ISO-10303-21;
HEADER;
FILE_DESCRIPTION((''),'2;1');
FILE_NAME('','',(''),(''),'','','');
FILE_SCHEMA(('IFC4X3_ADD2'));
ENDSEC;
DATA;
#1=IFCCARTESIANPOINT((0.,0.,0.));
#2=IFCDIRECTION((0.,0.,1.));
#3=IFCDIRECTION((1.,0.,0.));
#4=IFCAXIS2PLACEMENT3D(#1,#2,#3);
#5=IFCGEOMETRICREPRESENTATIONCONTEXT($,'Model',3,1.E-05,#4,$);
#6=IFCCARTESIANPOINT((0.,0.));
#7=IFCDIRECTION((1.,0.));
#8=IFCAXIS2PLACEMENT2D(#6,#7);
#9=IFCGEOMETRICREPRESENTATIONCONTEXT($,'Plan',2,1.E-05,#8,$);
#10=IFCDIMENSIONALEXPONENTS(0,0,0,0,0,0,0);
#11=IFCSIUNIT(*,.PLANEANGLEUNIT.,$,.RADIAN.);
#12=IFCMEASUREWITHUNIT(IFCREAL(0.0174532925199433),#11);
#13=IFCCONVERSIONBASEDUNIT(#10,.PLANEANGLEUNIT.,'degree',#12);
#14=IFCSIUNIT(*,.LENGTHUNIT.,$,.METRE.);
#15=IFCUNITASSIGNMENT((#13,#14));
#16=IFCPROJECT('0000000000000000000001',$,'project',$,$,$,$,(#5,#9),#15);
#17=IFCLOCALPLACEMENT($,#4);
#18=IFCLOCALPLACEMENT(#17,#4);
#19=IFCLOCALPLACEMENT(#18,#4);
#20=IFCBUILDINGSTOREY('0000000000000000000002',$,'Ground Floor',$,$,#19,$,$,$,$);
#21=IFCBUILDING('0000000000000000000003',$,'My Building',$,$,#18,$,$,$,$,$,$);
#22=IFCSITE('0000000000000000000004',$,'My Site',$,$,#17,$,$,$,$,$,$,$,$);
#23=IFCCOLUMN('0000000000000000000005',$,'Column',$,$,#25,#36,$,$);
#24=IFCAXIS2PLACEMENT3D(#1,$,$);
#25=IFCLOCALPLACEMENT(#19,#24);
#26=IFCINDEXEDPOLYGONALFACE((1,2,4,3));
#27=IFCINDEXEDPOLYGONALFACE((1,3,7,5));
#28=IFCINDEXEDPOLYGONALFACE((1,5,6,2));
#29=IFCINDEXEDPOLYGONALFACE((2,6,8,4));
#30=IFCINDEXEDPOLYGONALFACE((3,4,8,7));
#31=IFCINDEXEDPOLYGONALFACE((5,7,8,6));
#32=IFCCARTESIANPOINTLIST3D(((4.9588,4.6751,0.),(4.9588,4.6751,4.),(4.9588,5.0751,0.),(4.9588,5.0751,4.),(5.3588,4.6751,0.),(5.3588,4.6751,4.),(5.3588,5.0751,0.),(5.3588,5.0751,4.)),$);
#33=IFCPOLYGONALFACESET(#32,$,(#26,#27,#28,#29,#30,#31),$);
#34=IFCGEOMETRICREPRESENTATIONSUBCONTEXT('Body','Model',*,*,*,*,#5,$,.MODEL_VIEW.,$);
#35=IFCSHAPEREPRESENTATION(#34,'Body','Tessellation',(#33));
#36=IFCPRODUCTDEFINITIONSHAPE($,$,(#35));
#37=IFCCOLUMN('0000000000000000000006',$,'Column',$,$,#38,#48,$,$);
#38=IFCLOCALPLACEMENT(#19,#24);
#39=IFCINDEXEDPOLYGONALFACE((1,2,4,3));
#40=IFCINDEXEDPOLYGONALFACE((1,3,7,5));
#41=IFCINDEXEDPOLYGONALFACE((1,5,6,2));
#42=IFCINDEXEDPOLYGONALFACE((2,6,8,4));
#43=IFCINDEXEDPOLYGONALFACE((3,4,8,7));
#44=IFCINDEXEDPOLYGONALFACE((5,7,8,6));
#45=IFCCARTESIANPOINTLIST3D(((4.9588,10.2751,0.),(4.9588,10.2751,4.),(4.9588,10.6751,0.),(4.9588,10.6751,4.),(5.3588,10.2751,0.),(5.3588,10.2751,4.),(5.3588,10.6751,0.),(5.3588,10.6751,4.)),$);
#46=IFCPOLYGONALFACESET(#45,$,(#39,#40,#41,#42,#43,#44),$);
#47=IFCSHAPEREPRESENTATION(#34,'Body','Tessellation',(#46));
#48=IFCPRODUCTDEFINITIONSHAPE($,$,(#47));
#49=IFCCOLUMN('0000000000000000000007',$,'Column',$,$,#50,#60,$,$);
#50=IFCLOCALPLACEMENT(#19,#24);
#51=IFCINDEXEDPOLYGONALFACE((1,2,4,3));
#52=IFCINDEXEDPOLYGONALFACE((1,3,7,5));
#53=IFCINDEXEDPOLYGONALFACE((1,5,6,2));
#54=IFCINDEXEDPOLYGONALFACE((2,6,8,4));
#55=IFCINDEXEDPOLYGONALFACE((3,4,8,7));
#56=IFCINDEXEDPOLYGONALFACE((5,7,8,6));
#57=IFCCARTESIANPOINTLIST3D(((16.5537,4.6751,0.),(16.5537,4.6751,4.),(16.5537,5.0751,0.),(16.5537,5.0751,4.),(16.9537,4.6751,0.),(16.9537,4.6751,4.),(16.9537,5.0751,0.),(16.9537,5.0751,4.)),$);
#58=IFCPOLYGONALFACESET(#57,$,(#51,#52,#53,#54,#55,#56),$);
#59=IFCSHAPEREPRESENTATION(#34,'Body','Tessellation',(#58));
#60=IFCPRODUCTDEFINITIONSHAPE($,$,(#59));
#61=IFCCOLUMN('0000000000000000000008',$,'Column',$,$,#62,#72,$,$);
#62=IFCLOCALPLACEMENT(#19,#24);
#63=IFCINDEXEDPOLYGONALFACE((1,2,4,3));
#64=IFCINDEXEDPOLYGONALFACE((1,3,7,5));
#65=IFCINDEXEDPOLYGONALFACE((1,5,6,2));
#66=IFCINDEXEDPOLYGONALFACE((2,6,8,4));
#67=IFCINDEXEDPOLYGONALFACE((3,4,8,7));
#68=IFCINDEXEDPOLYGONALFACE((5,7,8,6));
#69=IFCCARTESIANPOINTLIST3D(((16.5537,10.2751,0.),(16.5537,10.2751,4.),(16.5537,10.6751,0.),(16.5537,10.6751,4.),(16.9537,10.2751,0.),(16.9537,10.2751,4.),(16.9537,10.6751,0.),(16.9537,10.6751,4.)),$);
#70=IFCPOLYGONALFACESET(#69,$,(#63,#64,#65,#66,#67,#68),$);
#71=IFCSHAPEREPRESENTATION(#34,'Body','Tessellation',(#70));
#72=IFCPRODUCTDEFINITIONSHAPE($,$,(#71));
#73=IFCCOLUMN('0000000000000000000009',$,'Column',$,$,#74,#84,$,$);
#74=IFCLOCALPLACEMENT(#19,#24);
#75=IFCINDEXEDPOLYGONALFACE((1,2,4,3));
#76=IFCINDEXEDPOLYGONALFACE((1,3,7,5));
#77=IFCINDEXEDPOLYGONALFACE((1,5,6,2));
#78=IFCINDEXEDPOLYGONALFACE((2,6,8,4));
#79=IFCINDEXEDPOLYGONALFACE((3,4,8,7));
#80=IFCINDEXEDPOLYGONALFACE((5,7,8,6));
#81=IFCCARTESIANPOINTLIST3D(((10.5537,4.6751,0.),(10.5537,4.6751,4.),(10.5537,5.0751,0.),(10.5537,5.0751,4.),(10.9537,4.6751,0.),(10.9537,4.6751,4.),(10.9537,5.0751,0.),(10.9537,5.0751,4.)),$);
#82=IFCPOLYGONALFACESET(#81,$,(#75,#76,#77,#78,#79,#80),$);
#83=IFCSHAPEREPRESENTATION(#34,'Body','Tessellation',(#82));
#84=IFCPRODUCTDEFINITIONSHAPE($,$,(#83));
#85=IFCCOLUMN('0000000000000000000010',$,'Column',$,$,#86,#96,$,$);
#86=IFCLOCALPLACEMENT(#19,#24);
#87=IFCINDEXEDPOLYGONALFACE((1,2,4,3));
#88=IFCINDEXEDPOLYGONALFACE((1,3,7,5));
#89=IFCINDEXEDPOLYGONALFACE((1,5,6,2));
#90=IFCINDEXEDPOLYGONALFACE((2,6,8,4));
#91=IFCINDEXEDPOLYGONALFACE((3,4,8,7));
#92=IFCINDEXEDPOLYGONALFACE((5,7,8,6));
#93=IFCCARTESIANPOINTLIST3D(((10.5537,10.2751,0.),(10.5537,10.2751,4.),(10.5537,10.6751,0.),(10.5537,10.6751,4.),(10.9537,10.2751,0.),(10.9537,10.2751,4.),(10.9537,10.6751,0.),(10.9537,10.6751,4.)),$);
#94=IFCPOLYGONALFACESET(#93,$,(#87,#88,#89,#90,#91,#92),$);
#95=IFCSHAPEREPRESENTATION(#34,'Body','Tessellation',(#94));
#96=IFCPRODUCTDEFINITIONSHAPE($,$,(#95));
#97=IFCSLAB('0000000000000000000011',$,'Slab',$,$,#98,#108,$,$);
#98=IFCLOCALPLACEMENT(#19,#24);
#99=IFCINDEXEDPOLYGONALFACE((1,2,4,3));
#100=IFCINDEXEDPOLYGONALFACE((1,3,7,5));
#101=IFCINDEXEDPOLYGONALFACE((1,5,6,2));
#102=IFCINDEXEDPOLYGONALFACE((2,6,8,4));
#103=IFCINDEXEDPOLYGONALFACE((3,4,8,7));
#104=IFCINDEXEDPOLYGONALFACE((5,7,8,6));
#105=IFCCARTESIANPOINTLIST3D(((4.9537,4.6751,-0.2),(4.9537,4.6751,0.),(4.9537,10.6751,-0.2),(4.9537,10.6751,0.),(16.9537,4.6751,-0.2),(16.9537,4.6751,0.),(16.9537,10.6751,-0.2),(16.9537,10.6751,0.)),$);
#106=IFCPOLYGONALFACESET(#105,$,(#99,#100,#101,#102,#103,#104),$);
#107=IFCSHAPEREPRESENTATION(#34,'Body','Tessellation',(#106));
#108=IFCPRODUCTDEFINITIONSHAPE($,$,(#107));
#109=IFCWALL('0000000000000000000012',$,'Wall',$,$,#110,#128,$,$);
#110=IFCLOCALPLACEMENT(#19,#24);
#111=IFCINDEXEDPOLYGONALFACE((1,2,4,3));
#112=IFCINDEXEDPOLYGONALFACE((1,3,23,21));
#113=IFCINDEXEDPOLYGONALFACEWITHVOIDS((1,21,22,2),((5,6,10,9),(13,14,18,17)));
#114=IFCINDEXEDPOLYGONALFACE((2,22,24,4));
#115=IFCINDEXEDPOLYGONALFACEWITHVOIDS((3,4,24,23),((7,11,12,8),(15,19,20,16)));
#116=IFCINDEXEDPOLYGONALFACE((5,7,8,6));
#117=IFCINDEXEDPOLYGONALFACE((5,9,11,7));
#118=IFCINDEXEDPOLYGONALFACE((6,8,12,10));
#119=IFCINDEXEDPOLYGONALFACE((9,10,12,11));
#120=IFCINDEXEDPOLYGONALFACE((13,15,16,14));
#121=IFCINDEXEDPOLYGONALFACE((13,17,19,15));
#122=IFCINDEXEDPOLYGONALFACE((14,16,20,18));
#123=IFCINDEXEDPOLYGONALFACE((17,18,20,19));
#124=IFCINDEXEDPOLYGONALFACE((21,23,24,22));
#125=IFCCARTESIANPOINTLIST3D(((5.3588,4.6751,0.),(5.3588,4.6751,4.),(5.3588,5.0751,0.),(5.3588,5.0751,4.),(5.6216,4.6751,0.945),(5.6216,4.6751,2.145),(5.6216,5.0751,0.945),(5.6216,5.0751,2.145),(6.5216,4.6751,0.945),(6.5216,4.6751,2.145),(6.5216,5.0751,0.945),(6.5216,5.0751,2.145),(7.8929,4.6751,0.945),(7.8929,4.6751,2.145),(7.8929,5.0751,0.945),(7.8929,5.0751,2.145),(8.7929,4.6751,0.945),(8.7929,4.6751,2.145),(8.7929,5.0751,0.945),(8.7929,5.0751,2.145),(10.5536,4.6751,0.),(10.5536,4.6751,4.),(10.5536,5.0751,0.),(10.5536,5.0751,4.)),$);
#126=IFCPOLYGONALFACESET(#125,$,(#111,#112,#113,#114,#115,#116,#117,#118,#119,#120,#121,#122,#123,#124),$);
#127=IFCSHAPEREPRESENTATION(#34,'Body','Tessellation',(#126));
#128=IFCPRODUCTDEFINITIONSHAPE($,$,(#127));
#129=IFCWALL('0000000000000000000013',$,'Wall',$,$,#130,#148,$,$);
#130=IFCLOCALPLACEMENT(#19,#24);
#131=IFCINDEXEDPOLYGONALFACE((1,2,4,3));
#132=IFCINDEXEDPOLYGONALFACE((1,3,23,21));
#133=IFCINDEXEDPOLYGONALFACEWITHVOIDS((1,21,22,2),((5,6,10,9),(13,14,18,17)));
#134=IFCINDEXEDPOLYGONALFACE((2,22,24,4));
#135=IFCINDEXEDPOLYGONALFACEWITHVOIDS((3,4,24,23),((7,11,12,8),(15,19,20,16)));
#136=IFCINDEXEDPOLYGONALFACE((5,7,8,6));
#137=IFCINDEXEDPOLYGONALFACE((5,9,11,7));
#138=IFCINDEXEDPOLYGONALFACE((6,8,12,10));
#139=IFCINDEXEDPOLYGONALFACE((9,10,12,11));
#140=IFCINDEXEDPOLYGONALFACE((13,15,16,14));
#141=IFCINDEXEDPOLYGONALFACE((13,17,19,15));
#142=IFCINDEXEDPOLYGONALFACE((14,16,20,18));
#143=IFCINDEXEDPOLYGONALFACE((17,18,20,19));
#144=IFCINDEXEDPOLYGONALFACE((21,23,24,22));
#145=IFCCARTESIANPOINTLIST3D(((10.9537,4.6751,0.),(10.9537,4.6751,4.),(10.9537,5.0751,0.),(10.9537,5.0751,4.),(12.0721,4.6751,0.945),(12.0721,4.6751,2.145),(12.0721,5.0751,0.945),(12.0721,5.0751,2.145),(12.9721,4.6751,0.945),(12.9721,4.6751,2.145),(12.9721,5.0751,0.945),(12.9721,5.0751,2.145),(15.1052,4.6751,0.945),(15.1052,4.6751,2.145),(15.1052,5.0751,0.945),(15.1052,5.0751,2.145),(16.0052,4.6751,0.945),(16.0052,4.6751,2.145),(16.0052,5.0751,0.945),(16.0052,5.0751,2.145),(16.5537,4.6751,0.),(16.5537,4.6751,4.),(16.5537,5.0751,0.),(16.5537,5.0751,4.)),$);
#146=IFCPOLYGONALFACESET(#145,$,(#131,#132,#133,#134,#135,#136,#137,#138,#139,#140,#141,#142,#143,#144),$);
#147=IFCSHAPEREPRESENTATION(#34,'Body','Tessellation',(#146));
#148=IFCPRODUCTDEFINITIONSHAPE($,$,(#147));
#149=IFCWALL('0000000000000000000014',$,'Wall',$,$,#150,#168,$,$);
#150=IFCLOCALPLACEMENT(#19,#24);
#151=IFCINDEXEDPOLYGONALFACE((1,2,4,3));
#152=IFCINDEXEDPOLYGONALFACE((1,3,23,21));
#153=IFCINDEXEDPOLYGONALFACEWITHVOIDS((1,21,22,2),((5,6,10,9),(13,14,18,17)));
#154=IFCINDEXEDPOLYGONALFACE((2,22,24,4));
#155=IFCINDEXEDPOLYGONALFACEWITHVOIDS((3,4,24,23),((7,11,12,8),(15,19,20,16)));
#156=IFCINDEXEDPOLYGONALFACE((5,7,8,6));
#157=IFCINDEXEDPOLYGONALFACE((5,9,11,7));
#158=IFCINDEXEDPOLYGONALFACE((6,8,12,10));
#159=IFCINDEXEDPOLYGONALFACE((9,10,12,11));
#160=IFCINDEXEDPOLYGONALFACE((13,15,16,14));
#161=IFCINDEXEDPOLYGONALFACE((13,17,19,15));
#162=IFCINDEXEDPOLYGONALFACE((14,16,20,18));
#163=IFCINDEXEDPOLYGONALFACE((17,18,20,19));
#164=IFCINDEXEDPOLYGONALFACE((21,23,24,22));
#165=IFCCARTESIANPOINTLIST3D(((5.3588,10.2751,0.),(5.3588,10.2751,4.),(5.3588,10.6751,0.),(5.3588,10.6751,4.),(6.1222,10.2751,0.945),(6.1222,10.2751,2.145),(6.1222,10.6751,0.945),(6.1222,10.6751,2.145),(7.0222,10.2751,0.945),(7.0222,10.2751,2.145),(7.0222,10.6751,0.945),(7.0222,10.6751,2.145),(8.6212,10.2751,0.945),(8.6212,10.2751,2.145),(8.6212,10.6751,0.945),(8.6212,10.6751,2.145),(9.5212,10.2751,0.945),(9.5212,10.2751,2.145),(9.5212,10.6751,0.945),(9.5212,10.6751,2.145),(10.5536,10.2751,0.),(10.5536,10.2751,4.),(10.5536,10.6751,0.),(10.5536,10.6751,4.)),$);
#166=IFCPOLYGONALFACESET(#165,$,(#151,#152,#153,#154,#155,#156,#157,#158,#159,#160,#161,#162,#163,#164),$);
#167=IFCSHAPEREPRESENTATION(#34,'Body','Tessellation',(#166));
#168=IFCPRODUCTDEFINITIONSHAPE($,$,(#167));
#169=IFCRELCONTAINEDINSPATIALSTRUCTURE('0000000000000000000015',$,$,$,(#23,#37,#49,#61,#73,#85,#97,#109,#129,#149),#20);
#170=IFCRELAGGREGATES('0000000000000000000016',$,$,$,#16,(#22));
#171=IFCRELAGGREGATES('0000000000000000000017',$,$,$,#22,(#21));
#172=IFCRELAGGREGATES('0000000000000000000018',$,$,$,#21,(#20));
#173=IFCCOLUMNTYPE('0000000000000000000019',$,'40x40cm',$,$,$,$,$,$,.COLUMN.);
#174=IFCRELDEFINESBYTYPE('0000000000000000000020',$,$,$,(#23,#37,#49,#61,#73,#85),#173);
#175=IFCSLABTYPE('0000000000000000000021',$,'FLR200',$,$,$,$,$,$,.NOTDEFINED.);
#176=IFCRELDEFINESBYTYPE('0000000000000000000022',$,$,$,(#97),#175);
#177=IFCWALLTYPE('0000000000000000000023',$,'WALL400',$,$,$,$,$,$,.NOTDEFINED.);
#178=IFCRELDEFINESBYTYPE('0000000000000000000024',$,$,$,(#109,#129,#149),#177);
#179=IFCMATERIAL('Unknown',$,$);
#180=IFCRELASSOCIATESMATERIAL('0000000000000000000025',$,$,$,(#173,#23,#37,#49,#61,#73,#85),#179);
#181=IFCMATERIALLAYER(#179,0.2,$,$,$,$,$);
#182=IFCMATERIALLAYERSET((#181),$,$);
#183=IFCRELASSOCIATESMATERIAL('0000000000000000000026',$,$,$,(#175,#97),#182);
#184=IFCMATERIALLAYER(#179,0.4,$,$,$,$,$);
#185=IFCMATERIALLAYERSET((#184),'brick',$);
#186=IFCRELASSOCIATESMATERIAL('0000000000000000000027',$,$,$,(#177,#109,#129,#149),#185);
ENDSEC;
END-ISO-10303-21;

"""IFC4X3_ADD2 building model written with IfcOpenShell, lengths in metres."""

from ifc_helpers import new_model, entity, si_unit, converted_unit, frame, origin_with_axes, origin_2d_with_axis, place, context, subcontext, project, spatial, line, indexed_curve, rectangle, outline, extrude, source, transform, mapped, material, layer, layer_set, layer_usage, material_profile, profile_set, profile_usage, type_object, element, save


model = new_model("IFC4X3_ADD2")

# Units and contexts
model_context = context("Model", 3, precision=1e-05, world=origin_with_axes())
plan_context = context("Plan", 2, precision=1e-05, world=origin_2d_with_axis())
body_context = subcontext(model_context, "Body", "Model", "MODEL_VIEW")
ifc_project = project(units=[converted_unit("PLANEANGLEUNIT", "degree", entity("IfcReal", 0.0174532925199433), si_unit("PLANEANGLEUNIT", "RADIAN"), dimensions=[0, 0, 0, 0, 0, 0, 0]), si_unit("LENGTHUNIT", "METRE")], contexts=[model_context, plan_context])

# Site, building, storey
site_placement = place(None, origin_with_axes())
site = spatial("IfcSite", under=ifc_project, at=site_placement, Name="My Site")
building_placement = place(site_placement, origin_with_axes())
building = spatial("IfcBuilding", under=site, at=building_placement, Name="My Building")
storey_placement = place(building_placement, origin_with_axes())
storey = spatial("IfcBuildingStorey", under=building, at=storey_placement, Name="Ground Floor")

# Columns
ifc_material = material(Name="Unknown")
ifc_material_profile = material_profile(ifc_material, rectangle(XDim=0.4, YDim=0.4))
ifc_profile_set = profile_set([ifc_material_profile])
ifc_profile_usage_1 = profile_usage(ifc_profile_set, cardinal=5)
column_type = type_object("IfcColumnType", Name="40x40cm", PredefinedType="COLUMN", material=ifc_profile_set)
column_1_placement = place(storey_placement, frame((5.1588, 4.8751, 0.0), z_axis=(0.0, 0.0, 1.0), x_axis=(1.0, 0.0, 0.0)))
element("IfcColumn", 1, at=column_1_placement, inside=storey, type_object=column_type, material=ifc_profile_usage_1, Name="Column", context=body_context, shape_type="SweptSolid", body=[
    extrude(rectangle(XDim=0.4, YDim=0.4), origin_with_axes(), (0.0, 0.0, 1.0), 4.0),
])
ifc_profile_usage_2 = profile_usage(ifc_profile_set, cardinal=5)
column_2_placement = place(storey_placement, frame((5.1588, 10.4751, 0.0), z_axis=(0.0, 0.0, 1.0), x_axis=(1.0, 0.0, 0.0)))
element("IfcColumn", 2, at=column_2_placement, inside=storey, type_object=column_type, material=ifc_profile_usage_2, Name="Column", context=body_context, shape_type="SweptSolid", body=[
    extrude(rectangle(XDim=0.4, YDim=0.4), origin_with_axes(), (0.0, 0.0, 1.0), 4.0),
])
ifc_profile_usage_3 = profile_usage(ifc_profile_set, cardinal=5)
column_3_placement = place(storey_placement, frame((16.7537, 4.8751, 0.0), z_axis=(0.0, 0.0, 1.0), x_axis=(1.0, 0.0, 0.0)))
element("IfcColumn", 3, at=column_3_placement, inside=storey, type_object=column_type, material=ifc_profile_usage_3, Name="Column", context=body_context, shape_type="SweptSolid", body=[
    extrude(rectangle(XDim=0.4, YDim=0.4), origin_with_axes(), (0.0, 0.0, 1.0), 4.0),
])
ifc_profile_usage_4 = profile_usage(ifc_profile_set, cardinal=5)
column_4_placement = place(storey_placement, frame((16.7537, 10.4751, 0.0), z_axis=(0.0, 0.0, 1.0), x_axis=(1.0, 0.0, 0.0)))
element("IfcColumn", 4, at=column_4_placement, inside=storey, type_object=column_type, material=ifc_profile_usage_4, Name="Column", context=body_context, shape_type="SweptSolid", body=[
    extrude(rectangle(XDim=0.4, YDim=0.4), origin_with_axes(), (0.0, 0.0, 1.0), 4.0),
])
ifc_profile_usage_5 = profile_usage(ifc_profile_set, cardinal=5)
column_5_placement = place(storey_placement, frame((10.7537, 4.8751, 0.0), z_axis=(0.0, 0.0, 1.0), x_axis=(1.0, 0.0, 0.0)))
element("IfcColumn", 5, at=column_5_placement, inside=storey, type_object=column_type, material=ifc_profile_usage_5, Name="Column", context=body_context, shape_type="SweptSolid", body=[
    extrude(rectangle(XDim=0.4, YDim=0.4), origin_with_axes(), (0.0, 0.0, 1.0), 4.0),
])
ifc_profile_usage_6 = profile_usage(ifc_profile_set, cardinal=5)
column_6_placement = place(storey_placement, frame((10.7537, 10.4751, 0.0), z_axis=(0.0, 0.0, 1.0), x_axis=(1.0, 0.0, 0.0)))
element("IfcColumn", 6, at=column_6_placement, inside=storey, type_object=column_type, material=ifc_profile_usage_6, Name="Column", context=body_context, shape_type="SweptSolid", body=[
    extrude(rectangle(XDim=0.4, YDim=0.4), origin_with_axes(), (0.0, 0.0, 1.0), 4.0),
])

# Slab
ifc_layer_1 = layer(ifc_material, 0.2)
ifc_layer_set_1 = layer_set([ifc_layer_1])
ifc_layer_usage_1 = layer_usage(ifc_layer_set_1, "AXIS3", "POSITIVE", -0.2)
slab_type = type_object("IfcSlabType", Name="FLR200", PredefinedType="NOTDEFINED", material=ifc_layer_set_1)
slab_placement = place(storey_placement, frame((4.9537, 4.6751, 0.0), z_axis=(0.0, 0.0, 1.0), x_axis=(1.0, 0.0, 0.0)))
element("IfcSlab", 7, at=slab_placement, inside=storey, type_object=slab_type, material=ifc_layer_usage_1, Name="Slab", context=body_context, shape_type="SweptSolid", body=[
    extrude(outline(indexed_curve([(0.0, 6.0), (12.0, 6.0), (12.0, 0.0), (0.0, 0.0), (0.0, 6.0)])), frame((0.0, 0.0, -0.2), z_axis=(0.0, 0.0, 1.0), x_axis=(1.0, 0.0, 0.0)), (0.0, 0.0, 1.0), 0.2),
])

# Walls, openings
ifc_layer_2 = layer(ifc_material, 0.4)
ifc_layer_set_2 = layer_set([ifc_layer_2], Name="brick")
ifc_layer_usage_2 = layer_usage(ifc_layer_set_2, "AXIS2", "POSITIVE", 0.0)
wall_type = type_object("IfcWallType", Name="WALL400", PredefinedType="NOTDEFINED", material=ifc_layer_set_2)
wall_1_placement = place(storey_placement, frame((5.3588, 4.6751, 0.0), z_axis=(0.0, 0.0, 1.0), x_axis=(1.0, 0.0, 0.0)))
wall_1 = element("IfcWall", 8, at=wall_1_placement, inside=storey, type_object=wall_type, material=ifc_layer_usage_2, Name="Wall", context=body_context, shape_type="SweptSolid", body=[
    extrude(outline(indexed_curve([(0.0, 0.0), (0.0, 0.4), (5.1949, 0.4), (5.1949, 0.0)], segments=[line(1, 2, 3, 4, 1)])), origin_with_axes(), (0.0, 0.0, 1.0), 4.0),
])
shared_shape_1 = source(origin_with_axes(), body_context, "Body", "SweptSolid", [
    extrude(outline(indexed_curve([(0.0, 0.0), (0.9, 0.0), (0.9, 1.2), (0.0, 1.2)], segments=[line(1, 2, 3, 4, 1)])), frame((0.0, -0.6, 0.0), z_axis=(0.0, -1.0, 0.0), x_axis=(1.0, 0.0, 0.0)), (0.0, 0.0, -1.0), 1.2),
])
opening_1_placement = place(wall_1_placement, frame((0.2628, 0.0, 0.945), z_axis=(0.0, 0.0, 1.0), x_axis=(1.0, 0.0, 0.0)))
element("IfcOpeningElement", 9, at=opening_1_placement, cuts=wall_1, PredefinedType="OPENING", context=body_context, shape_type="MappedRepresentation", body=[
    mapped(shared_shape_1, transform((0.0, 0.0, 0.0), x_axis=(1.0, 0.0, 0.0), y_axis=(0.0, 1.0, 0.0), z_axis=(0.0, 0.0, 1.0), scale=1.0)),
])
opening_2_placement = place(wall_1_placement, frame((2.5341, 0.0, 0.945), z_axis=(0.0, 0.0, 1.0), x_axis=(1.0, 0.0, 0.0)))
element("IfcOpeningElement", 10, at=opening_2_placement, cuts=wall_1, PredefinedType="OPENING", context=body_context, shape_type="MappedRepresentation", body=[
    mapped(shared_shape_1, transform((0.0, 0.0, 0.0), x_axis=(1.0, 0.0, 0.0), y_axis=(0.0, 1.0, 0.0), z_axis=(0.0, 0.0, 1.0), scale=1.0)),
])
ifc_layer_usage_3 = layer_usage(ifc_layer_set_2, "AXIS2", "POSITIVE", 0.0)
wall_2_placement = place(storey_placement, frame((10.9537, 4.6751, 0.0), z_axis=(0.0, 0.0, 1.0), x_axis=(1.0, 0.0, 0.0)))
wall_2 = element("IfcWall", 11, at=wall_2_placement, inside=storey, type_object=wall_type, material=ifc_layer_usage_3, Name="Wall", context=body_context, shape_type="SweptSolid", body=[
    extrude(outline(indexed_curve([(0.0, 0.0), (0.0, 0.4), (5.6, 0.4), (5.6, 0.0)], segments=[line(1, 2, 3, 4, 1)])), origin_with_axes(), (0.0, 0.0, 1.0), 4.0),
])
opening_3_placement = place(wall_2_placement, frame((1.1184, 0.0, 0.945), z_axis=(0.0, 0.0, 1.0), x_axis=(1.0, 0.0, 0.0)))
element("IfcOpeningElement", 12, at=opening_3_placement, cuts=wall_2, PredefinedType="OPENING", context=body_context, shape_type="MappedRepresentation", body=[
    mapped(shared_shape_1, transform((0.0, 0.0, 0.0), x_axis=(1.0, 0.0, 0.0), y_axis=(0.0, 1.0, 0.0), z_axis=(0.0, 0.0, 1.0), scale=1.0)),
])
opening_4_placement = place(wall_2_placement, frame((4.1515, 0.0, 0.945), z_axis=(0.0, 0.0, 1.0), x_axis=(1.0, 0.0, 0.0)))
element("IfcOpeningElement", 13, at=opening_4_placement, cuts=wall_2, PredefinedType="OPENING", context=body_context, shape_type="MappedRepresentation", body=[
    mapped(shared_shape_1, transform((0.0, 0.0, 0.0), x_axis=(1.0, 0.0, 0.0), y_axis=(0.0, 1.0, 0.0), z_axis=(0.0, 0.0, 1.0), scale=1.0)),
])
ifc_layer_usage_4 = layer_usage(ifc_layer_set_2, "AXIS2", "POSITIVE", 0.0)
wall_3_placement = place(storey_placement, frame((5.3588, 10.2751, 0.0), z_axis=(0.0, 0.0, 1.0), x_axis=(1.0, 0.0, 0.0)))
wall_3 = element("IfcWall", 14, at=wall_3_placement, inside=storey, type_object=wall_type, material=ifc_layer_usage_4, Name="Wall", context=body_context, shape_type="SweptSolid", body=[
    extrude(outline(indexed_curve([(0.0, 0.0), (0.0, 0.4), (5.1949, 0.4), (5.1949, 0.0)], segments=[line(1, 2, 3, 4, 1)])), origin_with_axes(), (0.0, 0.0, 1.0), 4.0),
])
opening_5_placement = place(wall_3_placement, frame((4.1624, 0.4, 0.945), z_axis=(0.0, 0.0, 1.0), x_axis=(-1.0, 0.0, 0.0)))
element("IfcOpeningElement", 15, at=opening_5_placement, cuts=wall_3, PredefinedType="OPENING", context=body_context, shape_type="MappedRepresentation", body=[
    mapped(shared_shape_1, transform((0.0, 0.0, 0.0), x_axis=(1.0, 0.0, 0.0), y_axis=(0.0, 1.0, 0.0), z_axis=(0.0, 0.0, 1.0), scale=1.0)),
])
opening_6_placement = place(wall_3_placement, frame((1.6634, 0.4, 0.945), z_axis=(0.0, 0.0, 1.0), x_axis=(-1.0, 0.0, 0.0)))
element("IfcOpeningElement", 16, at=opening_6_placement, cuts=wall_3, PredefinedType="OPENING", context=body_context, shape_type="MappedRepresentation", body=[
    mapped(shared_shape_1, transform((0.0, 0.0, 0.0), x_axis=(1.0, 0.0, 0.0), y_axis=(0.0, 1.0, 0.0), z_axis=(0.0, 0.0, 1.0), scale=1.0)),
])

save(model, "model.ifc")
